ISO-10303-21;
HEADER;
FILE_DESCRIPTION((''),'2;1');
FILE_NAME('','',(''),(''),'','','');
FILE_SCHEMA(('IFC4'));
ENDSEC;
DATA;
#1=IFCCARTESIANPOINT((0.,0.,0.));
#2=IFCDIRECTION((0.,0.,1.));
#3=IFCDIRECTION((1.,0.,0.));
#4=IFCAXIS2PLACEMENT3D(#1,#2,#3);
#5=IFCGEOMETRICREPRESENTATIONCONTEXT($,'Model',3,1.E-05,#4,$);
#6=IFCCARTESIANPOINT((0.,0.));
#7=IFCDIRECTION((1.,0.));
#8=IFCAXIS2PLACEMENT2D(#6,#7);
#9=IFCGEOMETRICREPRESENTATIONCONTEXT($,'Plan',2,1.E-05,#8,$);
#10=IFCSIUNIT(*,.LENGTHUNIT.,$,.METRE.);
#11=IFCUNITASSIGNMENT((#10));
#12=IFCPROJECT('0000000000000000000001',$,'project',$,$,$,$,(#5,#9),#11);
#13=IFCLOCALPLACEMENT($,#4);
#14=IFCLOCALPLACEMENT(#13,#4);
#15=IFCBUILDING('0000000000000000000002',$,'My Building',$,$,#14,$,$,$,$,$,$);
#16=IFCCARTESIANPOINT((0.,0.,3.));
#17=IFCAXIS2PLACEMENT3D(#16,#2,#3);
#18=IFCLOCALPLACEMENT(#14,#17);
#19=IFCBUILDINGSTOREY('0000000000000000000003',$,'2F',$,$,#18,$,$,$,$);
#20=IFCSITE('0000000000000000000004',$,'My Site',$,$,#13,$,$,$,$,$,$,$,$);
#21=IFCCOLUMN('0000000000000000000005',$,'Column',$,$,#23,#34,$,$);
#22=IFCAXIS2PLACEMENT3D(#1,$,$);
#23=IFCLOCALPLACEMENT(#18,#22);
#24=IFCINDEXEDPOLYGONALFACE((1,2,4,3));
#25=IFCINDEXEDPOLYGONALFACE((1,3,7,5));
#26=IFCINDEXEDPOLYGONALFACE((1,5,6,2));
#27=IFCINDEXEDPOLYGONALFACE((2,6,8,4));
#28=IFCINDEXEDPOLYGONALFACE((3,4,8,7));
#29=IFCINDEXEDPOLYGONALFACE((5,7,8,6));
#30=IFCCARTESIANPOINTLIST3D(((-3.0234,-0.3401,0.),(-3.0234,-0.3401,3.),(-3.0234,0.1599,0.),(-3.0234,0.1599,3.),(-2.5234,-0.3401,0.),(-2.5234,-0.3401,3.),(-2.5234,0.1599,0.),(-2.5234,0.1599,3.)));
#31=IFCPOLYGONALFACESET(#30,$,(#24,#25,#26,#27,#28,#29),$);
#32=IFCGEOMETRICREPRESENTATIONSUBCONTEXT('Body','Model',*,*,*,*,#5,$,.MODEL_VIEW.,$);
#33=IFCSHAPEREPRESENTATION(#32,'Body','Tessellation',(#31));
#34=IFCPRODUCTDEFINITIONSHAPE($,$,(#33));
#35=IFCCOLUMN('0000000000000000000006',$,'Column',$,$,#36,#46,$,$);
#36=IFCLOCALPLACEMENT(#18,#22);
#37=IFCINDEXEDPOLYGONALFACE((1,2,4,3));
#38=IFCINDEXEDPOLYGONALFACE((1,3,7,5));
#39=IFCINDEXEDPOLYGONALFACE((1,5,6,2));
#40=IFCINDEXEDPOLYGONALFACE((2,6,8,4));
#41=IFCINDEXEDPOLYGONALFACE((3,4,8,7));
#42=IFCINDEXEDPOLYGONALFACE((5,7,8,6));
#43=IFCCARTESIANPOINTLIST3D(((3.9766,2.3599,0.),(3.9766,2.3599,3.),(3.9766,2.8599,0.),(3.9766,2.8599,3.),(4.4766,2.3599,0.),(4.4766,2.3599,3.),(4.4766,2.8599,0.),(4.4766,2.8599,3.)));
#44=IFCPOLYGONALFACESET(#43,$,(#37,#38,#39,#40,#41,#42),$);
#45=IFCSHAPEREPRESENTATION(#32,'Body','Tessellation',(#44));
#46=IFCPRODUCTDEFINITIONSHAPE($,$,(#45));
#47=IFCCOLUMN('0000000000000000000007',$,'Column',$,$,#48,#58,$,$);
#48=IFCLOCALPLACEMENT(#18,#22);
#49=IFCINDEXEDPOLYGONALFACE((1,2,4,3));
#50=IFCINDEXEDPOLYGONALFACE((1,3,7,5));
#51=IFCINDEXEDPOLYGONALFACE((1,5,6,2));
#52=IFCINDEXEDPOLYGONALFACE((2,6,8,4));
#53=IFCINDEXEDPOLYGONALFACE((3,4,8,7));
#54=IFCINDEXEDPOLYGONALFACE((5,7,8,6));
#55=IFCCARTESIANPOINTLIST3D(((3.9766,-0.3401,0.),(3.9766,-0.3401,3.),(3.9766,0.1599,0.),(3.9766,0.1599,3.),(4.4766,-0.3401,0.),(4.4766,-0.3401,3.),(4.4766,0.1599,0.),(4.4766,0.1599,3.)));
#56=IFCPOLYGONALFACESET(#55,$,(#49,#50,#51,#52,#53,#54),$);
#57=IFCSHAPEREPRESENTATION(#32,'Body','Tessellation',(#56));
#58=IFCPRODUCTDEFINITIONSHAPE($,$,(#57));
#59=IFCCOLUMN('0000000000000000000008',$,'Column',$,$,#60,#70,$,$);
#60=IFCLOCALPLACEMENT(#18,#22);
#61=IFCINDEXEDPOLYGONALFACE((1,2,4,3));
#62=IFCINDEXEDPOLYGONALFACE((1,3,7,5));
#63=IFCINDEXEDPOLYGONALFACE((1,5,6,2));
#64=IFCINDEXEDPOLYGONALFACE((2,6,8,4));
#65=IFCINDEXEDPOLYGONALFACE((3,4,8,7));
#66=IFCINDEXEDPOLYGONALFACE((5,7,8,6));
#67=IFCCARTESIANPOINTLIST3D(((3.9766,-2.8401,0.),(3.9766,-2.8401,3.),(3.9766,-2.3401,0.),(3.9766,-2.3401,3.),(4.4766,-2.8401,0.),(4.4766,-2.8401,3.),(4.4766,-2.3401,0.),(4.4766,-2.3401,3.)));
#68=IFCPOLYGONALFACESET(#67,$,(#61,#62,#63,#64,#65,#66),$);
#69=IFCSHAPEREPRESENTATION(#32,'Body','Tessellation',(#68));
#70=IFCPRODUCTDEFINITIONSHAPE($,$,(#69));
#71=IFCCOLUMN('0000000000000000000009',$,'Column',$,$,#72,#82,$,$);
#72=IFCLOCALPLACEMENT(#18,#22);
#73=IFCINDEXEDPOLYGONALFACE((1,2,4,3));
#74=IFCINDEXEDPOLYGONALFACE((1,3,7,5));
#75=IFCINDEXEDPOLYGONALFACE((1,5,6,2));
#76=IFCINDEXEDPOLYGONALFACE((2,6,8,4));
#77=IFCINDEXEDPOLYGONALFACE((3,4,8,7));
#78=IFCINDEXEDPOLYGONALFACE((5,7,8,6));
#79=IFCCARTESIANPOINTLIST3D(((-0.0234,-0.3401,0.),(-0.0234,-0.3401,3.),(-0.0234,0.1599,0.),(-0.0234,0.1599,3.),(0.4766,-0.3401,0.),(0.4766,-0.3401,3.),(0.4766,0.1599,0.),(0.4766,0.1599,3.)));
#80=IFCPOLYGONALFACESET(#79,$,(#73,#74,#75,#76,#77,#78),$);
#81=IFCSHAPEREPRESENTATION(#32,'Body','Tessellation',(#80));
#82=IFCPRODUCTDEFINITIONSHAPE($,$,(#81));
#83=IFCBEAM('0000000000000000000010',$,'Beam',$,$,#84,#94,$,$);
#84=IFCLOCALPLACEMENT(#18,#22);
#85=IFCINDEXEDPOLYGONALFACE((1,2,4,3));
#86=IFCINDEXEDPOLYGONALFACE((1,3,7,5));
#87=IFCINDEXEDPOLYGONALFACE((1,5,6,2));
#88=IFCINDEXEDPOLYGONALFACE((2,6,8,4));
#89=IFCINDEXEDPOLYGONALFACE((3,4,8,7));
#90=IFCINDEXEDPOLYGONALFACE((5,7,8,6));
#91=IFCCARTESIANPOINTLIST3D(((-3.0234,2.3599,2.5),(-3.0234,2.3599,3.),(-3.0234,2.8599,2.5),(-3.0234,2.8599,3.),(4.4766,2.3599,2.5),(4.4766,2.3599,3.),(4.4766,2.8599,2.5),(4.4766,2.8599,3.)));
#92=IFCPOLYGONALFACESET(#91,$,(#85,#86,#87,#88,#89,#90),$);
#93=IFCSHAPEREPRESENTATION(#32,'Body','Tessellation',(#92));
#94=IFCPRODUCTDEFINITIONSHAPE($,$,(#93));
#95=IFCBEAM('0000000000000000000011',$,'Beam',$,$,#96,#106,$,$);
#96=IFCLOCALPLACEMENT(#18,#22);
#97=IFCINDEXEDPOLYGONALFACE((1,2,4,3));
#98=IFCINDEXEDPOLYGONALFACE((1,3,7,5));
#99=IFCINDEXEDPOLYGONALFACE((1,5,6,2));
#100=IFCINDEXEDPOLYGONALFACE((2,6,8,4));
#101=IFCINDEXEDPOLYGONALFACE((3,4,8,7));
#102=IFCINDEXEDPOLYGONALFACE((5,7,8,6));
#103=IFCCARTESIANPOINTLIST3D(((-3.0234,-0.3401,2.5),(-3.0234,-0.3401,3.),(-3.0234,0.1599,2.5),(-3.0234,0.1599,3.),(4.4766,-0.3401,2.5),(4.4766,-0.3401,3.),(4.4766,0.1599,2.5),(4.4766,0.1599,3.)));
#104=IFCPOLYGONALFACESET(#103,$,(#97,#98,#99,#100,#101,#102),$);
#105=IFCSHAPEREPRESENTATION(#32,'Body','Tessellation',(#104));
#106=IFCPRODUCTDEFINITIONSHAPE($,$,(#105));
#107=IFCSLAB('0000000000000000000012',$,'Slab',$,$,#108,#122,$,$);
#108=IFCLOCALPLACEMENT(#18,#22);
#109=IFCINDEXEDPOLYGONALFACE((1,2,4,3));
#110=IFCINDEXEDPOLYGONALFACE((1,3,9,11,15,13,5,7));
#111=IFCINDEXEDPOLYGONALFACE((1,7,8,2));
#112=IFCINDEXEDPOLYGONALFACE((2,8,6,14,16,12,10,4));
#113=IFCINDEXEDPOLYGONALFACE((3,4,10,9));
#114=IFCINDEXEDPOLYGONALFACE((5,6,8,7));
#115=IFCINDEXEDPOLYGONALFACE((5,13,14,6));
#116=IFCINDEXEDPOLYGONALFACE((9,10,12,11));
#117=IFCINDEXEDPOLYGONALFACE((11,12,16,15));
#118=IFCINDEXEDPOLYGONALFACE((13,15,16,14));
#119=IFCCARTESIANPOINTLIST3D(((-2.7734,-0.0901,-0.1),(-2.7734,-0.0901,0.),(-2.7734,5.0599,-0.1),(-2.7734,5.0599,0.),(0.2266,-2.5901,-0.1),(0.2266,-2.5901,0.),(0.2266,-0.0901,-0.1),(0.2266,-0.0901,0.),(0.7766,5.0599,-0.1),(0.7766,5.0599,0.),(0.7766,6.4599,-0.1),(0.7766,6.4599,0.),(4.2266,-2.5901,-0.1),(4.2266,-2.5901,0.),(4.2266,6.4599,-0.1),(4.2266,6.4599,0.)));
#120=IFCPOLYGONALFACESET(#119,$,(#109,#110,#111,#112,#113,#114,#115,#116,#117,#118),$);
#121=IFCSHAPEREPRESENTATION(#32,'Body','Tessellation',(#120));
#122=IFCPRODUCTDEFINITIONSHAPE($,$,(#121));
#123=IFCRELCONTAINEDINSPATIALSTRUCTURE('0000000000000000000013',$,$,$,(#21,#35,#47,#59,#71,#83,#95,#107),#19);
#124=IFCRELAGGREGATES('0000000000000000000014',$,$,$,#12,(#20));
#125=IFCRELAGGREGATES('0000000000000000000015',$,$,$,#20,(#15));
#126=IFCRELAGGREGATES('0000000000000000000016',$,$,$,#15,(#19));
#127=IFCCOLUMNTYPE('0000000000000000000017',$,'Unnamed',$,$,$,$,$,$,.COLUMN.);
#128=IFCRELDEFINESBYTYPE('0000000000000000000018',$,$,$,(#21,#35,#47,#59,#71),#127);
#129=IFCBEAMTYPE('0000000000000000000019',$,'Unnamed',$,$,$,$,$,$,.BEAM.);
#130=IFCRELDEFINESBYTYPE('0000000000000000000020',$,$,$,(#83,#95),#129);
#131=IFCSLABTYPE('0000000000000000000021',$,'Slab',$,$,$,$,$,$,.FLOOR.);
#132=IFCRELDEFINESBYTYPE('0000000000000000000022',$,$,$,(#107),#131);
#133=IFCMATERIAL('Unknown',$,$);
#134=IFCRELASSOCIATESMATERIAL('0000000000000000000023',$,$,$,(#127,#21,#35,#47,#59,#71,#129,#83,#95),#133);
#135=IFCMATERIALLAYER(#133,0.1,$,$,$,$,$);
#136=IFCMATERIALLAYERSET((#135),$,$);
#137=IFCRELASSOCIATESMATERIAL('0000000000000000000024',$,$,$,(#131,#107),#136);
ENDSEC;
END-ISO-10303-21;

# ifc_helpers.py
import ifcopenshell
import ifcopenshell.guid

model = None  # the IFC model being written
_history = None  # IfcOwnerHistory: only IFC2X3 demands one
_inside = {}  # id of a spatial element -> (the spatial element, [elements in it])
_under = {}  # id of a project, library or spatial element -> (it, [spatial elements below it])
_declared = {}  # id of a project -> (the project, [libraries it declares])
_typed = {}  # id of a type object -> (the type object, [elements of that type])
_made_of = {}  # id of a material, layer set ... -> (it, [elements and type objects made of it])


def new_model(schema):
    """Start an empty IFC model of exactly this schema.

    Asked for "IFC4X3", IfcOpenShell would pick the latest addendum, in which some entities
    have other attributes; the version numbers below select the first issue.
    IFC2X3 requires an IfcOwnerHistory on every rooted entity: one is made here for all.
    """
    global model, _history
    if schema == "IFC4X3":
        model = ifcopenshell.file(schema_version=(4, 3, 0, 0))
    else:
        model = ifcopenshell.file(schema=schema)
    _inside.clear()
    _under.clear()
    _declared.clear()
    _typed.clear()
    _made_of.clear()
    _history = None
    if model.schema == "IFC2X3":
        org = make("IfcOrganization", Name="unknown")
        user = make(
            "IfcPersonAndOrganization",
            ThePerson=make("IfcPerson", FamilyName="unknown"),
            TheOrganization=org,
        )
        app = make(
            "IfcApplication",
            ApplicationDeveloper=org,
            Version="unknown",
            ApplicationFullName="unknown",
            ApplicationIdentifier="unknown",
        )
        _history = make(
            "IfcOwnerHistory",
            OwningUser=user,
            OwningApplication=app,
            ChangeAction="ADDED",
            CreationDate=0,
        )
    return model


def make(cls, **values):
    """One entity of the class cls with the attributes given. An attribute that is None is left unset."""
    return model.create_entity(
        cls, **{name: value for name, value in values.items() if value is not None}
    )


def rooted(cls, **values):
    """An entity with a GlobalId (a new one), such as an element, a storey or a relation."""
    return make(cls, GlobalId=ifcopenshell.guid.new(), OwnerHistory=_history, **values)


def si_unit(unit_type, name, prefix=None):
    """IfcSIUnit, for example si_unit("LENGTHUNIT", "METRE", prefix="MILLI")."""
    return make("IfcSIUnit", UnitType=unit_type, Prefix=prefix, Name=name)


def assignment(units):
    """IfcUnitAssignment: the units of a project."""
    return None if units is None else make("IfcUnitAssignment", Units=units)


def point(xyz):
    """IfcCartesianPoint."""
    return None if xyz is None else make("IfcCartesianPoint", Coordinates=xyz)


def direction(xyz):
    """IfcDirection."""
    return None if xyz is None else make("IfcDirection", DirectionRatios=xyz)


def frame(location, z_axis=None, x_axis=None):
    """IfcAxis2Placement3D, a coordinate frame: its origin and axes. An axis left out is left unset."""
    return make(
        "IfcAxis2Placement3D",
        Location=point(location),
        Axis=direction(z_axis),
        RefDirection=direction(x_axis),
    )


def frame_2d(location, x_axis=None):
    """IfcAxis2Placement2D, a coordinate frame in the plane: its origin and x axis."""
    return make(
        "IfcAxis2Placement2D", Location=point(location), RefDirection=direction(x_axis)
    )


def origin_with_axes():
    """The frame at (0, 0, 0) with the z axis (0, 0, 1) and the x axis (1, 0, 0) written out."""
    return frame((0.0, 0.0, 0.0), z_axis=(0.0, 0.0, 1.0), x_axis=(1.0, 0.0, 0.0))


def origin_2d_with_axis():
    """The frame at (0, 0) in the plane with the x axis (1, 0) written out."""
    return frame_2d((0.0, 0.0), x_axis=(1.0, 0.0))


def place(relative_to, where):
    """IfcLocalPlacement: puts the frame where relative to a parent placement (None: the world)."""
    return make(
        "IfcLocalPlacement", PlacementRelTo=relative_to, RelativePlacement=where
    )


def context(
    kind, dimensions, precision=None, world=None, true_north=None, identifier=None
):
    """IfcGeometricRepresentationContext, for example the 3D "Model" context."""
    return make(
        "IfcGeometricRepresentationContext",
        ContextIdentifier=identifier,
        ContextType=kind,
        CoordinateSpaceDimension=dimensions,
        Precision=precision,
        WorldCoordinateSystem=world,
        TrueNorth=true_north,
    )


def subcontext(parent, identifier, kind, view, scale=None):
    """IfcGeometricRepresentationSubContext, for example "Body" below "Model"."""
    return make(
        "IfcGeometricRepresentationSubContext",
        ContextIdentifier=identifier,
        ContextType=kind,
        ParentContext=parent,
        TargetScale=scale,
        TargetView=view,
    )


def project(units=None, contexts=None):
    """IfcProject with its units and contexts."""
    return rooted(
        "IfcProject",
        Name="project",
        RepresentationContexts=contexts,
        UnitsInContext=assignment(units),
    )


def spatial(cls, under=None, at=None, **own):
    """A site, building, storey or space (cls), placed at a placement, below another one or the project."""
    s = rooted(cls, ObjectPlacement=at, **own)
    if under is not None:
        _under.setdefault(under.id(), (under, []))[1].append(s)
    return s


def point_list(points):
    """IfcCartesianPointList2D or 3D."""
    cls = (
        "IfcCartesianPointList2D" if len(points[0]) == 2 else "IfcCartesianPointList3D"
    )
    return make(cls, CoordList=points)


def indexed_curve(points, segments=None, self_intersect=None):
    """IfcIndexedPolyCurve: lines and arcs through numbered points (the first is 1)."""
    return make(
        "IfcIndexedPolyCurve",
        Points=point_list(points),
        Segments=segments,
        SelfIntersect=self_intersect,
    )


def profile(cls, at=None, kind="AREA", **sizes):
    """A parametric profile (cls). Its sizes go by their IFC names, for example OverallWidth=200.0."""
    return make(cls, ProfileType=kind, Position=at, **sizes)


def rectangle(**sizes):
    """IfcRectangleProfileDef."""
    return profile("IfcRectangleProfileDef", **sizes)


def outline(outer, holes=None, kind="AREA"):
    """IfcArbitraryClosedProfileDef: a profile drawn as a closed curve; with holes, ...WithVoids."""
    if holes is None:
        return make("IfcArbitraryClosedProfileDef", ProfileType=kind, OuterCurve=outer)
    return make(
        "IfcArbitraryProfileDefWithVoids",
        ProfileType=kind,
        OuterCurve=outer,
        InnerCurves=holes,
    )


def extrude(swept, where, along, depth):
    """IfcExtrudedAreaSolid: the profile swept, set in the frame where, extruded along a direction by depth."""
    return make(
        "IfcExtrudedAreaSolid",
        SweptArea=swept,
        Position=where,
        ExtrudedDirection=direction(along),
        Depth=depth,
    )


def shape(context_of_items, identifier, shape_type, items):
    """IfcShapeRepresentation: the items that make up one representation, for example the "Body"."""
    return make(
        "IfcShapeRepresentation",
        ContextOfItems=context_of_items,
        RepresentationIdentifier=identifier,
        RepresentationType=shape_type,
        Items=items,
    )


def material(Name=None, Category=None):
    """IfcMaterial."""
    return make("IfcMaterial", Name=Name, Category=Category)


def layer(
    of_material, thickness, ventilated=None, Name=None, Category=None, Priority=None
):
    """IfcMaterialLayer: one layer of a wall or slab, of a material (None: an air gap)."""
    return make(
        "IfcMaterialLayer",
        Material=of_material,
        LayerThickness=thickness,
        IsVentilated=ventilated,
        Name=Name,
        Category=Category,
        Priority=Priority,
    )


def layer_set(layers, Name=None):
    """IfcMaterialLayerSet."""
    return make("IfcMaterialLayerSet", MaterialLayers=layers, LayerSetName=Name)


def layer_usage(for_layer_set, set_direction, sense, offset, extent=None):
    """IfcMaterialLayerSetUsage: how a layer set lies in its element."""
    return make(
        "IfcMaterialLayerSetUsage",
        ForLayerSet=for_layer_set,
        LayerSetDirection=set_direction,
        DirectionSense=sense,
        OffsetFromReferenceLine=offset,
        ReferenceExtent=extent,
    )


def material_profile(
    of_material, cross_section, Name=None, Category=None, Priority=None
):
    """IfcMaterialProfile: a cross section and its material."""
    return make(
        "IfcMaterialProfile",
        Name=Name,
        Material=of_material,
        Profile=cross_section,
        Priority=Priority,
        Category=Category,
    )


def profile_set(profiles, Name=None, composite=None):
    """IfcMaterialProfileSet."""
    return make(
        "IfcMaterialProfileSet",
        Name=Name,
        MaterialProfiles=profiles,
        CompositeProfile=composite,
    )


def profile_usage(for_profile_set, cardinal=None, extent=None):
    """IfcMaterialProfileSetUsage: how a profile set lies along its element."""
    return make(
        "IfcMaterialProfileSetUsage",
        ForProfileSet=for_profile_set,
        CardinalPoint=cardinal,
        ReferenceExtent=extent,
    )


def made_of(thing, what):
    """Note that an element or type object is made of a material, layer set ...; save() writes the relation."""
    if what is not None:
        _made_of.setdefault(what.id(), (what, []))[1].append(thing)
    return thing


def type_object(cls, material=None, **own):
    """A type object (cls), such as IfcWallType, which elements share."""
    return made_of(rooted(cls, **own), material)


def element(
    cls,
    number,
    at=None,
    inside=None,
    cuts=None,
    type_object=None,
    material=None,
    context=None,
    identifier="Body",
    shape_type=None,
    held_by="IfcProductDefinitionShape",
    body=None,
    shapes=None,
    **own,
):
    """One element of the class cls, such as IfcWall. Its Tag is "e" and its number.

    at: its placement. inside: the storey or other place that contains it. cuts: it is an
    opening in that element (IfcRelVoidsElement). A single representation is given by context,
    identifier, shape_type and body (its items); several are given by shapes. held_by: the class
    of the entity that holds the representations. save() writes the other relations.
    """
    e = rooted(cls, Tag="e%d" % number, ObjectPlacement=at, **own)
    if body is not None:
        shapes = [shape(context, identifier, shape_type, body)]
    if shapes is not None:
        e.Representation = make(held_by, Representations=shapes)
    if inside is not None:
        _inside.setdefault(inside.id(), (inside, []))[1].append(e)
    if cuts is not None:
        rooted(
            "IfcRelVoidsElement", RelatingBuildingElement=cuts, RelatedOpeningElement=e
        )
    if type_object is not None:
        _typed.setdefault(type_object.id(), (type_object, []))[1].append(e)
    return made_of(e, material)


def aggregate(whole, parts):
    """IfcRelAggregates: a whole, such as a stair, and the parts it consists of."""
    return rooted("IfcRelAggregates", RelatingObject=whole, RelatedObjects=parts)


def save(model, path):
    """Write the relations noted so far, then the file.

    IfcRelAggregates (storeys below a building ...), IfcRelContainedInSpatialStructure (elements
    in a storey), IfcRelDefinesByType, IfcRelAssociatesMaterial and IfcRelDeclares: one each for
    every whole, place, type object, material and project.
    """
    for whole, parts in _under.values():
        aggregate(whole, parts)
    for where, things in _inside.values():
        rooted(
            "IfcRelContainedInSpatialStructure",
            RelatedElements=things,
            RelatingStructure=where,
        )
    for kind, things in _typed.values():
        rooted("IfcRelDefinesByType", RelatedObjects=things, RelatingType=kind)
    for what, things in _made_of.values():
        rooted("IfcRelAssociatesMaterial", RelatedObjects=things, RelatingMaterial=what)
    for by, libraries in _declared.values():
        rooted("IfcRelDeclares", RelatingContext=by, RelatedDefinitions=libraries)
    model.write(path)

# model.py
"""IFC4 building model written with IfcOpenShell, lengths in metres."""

from ifc_helpers import new_model, si_unit, frame, origin_with_axes, origin_2d_with_axis, place, context, subcontext, project, spatial, indexed_curve, rectangle, outline, extrude, material, layer, layer_set, layer_usage, material_profile, profile_set, profile_usage, type_object, element, save


model = new_model("IFC4")

# Units and contexts
model_context = context("Model", 3, precision=1e-05, world=origin_with_axes())
plan_context = context("Plan", 2, precision=1e-05, world=origin_2d_with_axis())
body_context_1 = subcontext(model_context, "Body", "Model", "MODEL_VIEW")
ifc_project = project(units=[si_unit("LENGTHUNIT", "METRE")], contexts=[model_context, plan_context])

# Site, building, storey
site_placement = place(None, origin_with_axes())
site = spatial("IfcSite", under=ifc_project, at=site_placement, Name="My Site")
building_placement = place(site_placement, origin_with_axes())
building = spatial("IfcBuilding", under=site, at=building_placement, Name="My Building")
storey_placement = place(building_placement, frame((0.0, 0.0, 3.0), z_axis=(0.0, 0.0, 1.0), x_axis=(1.0, 0.0, 0.0)))
storey = spatial("IfcBuildingStorey", under=building, at=storey_placement, Name="2F")

# Columns
ifc_material = material(Name="Unknown")
ifc_material_profile_1 = material_profile(ifc_material, rectangle(XDim=0.5, YDim=0.5))
ifc_profile_set_1 = profile_set([ifc_material_profile_1])
ifc_profile_usage_1 = profile_usage(ifc_profile_set_1, cardinal=5)
column_type = type_object("IfcColumnType", Name="Unnamed", PredefinedType="COLUMN", material=ifc_profile_set_1)
column_1_placement = place(storey_placement, frame((-2.7734, -0.0901, 0.0), z_axis=(0.0, 0.0, 1.0), x_axis=(1.0, 0.0, 0.0)))
element("IfcColumn", 1, at=column_1_placement, inside=storey, type_object=column_type, material=ifc_profile_usage_1, Name="Column", context=body_context_1, shape_type="SweptSolid", body=[
    extrude(rectangle(XDim=0.5, YDim=0.5), origin_with_axes(), (0.0, 0.0, 1.0), 3.0),
])
ifc_profile_usage_2 = profile_usage(ifc_profile_set_1, cardinal=5)
column_2_placement = place(storey_placement, frame((4.2266, 2.6099, 0.0), z_axis=(0.0, 0.0, 1.0), x_axis=(1.0, 0.0, 0.0)))
element("IfcColumn", 2, at=column_2_placement, inside=storey, type_object=column_type, material=ifc_profile_usage_2, Name="Column", context=body_context_1, shape_type="SweptSolid", body=[
    extrude(rectangle(XDim=0.5, YDim=0.5), origin_with_axes(), (0.0, 0.0, 1.0), 3.0),
])
ifc_profile_usage_3 = profile_usage(ifc_profile_set_1, cardinal=5)
column_3_placement = place(storey_placement, frame((4.2266, -0.0901, 0.0), z_axis=(0.0, 0.0, 1.0), x_axis=(1.0, 0.0, 0.0)))
element("IfcColumn", 3, at=column_3_placement, inside=storey, type_object=column_type, material=ifc_profile_usage_3, Name="Column", context=body_context_1, shape_type="SweptSolid", body=[
    extrude(rectangle(XDim=0.5, YDim=0.5), origin_with_axes(), (0.0, 0.0, 1.0), 3.0),
])
ifc_profile_usage_4 = profile_usage(ifc_profile_set_1, cardinal=5)
column_4_placement = place(storey_placement, frame((4.2266, -2.5901, 0.0), z_axis=(0.0, 0.0, 1.0), x_axis=(1.0, 0.0, 0.0)))
element("IfcColumn", 4, at=column_4_placement, inside=storey, type_object=column_type, material=ifc_profile_usage_4, Name="Column", context=body_context_1, shape_type="SweptSolid", body=[
    extrude(rectangle(XDim=0.5, YDim=0.5), origin_with_axes(), (0.0, 0.0, 1.0), 3.0),
])
ifc_profile_usage_5 = profile_usage(ifc_profile_set_1, cardinal=5)
column_5_placement = place(storey_placement, frame((0.2266, -0.0901, 0.0), z_axis=(0.0, 0.0, 1.0), x_axis=(1.0, 0.0, 0.0)))
element("IfcColumn", 5, at=column_5_placement, inside=storey, type_object=column_type, material=ifc_profile_usage_5, Name="Column", context=body_context_1, shape_type="SweptSolid", body=[
    extrude(rectangle(XDim=0.5, YDim=0.5), origin_with_axes(), (0.0, 0.0, 1.0), 3.0),
])

# Beams
ifc_material_profile_2 = material_profile(ifc_material, rectangle(XDim=0.5, YDim=0.5))
ifc_profile_set_2 = profile_set([ifc_material_profile_2])
ifc_profile_usage_6 = profile_usage(ifc_profile_set_2, cardinal=7)
beam_type = type_object("IfcBeamType", Name="Unnamed", PredefinedType="BEAM", material=ifc_profile_set_2)
beam_1_placement = place(storey_placement, frame((4.4766, 2.3599, 3.0), z_axis=(-1.0, 0.0, 0.0), x_axis=(0.0, -1.0, 0.0)))
element("IfcBeam", 6, at=beam_1_placement, inside=storey, type_object=beam_type, material=ifc_profile_usage_6, Name="Beam", context=body_context_1, shape_type="SweptSolid", body=[
    extrude(rectangle(XDim=0.5, YDim=0.5), frame((-0.25, -0.25, 0.0), z_axis=(0.0, 0.0, 1.0), x_axis=(1.0, 0.0, 0.0)), (0.0, 0.0, 1.0), 7.5),
])
ifc_profile_usage_7 = profile_usage(ifc_profile_set_2, cardinal=7)
beam_2_placement = place(storey_placement, frame((4.4766, -0.3401, 3.0), z_axis=(-1.0, 0.0, 0.0), x_axis=(0.0, -1.0, 0.0)))
element("IfcBeam", 7, at=beam_2_placement, inside=storey, type_object=beam_type, material=ifc_profile_usage_7, Name="Beam", context=body_context_1, shape_type="SweptSolid", body=[
    extrude(rectangle(XDim=0.5, YDim=0.5), frame((-0.25, -0.25, 0.0), z_axis=(0.0, 0.0, 1.0), x_axis=(1.0, 0.0, 0.0)), (0.0, 0.0, 1.0), 7.5),
])

# Slab
ifc_layer_1 = layer(ifc_material, 0.1)
ifc_layer_set_1 = layer_set([ifc_layer_1])
ifc_layer_usage_1 = layer_usage(ifc_layer_set_1, "AXIS3", "POSITIVE", -0.1)
slab_type = type_object("IfcSlabType", Name="Slab", PredefinedType="FLOOR", material=ifc_layer_set_1)
slab_placement = place(storey_placement, frame((4.2266, -2.5901, 0.0), z_axis=(0.0, 0.0, 1.0), x_axis=(1.0, 0.0, 0.0)))
element("IfcSlab", 8, at=slab_placement, inside=storey, type_object=slab_type, material=ifc_layer_usage_1, Name="Slab", context=body_context_1, shape_type="SweptSolid", body=[
    extrude(outline(indexed_curve([(0.0, 0.0), (0.0, 9.05), (-3.45, 9.05), (-3.45, 7.65), (-7.0, 7.65), (-7.0, 2.5), (-4.0, 2.5), (-4.0, 0.0), (0.0, 0.0)])), frame((0.0, 0.0, -0.1), z_axis=(0.0, 0.0, 1.0), x_axis=(1.0, 0.0, 0.0)), (0.0, 0.0, 1.0), 0.1),
])

save(model, "model.ifc")
